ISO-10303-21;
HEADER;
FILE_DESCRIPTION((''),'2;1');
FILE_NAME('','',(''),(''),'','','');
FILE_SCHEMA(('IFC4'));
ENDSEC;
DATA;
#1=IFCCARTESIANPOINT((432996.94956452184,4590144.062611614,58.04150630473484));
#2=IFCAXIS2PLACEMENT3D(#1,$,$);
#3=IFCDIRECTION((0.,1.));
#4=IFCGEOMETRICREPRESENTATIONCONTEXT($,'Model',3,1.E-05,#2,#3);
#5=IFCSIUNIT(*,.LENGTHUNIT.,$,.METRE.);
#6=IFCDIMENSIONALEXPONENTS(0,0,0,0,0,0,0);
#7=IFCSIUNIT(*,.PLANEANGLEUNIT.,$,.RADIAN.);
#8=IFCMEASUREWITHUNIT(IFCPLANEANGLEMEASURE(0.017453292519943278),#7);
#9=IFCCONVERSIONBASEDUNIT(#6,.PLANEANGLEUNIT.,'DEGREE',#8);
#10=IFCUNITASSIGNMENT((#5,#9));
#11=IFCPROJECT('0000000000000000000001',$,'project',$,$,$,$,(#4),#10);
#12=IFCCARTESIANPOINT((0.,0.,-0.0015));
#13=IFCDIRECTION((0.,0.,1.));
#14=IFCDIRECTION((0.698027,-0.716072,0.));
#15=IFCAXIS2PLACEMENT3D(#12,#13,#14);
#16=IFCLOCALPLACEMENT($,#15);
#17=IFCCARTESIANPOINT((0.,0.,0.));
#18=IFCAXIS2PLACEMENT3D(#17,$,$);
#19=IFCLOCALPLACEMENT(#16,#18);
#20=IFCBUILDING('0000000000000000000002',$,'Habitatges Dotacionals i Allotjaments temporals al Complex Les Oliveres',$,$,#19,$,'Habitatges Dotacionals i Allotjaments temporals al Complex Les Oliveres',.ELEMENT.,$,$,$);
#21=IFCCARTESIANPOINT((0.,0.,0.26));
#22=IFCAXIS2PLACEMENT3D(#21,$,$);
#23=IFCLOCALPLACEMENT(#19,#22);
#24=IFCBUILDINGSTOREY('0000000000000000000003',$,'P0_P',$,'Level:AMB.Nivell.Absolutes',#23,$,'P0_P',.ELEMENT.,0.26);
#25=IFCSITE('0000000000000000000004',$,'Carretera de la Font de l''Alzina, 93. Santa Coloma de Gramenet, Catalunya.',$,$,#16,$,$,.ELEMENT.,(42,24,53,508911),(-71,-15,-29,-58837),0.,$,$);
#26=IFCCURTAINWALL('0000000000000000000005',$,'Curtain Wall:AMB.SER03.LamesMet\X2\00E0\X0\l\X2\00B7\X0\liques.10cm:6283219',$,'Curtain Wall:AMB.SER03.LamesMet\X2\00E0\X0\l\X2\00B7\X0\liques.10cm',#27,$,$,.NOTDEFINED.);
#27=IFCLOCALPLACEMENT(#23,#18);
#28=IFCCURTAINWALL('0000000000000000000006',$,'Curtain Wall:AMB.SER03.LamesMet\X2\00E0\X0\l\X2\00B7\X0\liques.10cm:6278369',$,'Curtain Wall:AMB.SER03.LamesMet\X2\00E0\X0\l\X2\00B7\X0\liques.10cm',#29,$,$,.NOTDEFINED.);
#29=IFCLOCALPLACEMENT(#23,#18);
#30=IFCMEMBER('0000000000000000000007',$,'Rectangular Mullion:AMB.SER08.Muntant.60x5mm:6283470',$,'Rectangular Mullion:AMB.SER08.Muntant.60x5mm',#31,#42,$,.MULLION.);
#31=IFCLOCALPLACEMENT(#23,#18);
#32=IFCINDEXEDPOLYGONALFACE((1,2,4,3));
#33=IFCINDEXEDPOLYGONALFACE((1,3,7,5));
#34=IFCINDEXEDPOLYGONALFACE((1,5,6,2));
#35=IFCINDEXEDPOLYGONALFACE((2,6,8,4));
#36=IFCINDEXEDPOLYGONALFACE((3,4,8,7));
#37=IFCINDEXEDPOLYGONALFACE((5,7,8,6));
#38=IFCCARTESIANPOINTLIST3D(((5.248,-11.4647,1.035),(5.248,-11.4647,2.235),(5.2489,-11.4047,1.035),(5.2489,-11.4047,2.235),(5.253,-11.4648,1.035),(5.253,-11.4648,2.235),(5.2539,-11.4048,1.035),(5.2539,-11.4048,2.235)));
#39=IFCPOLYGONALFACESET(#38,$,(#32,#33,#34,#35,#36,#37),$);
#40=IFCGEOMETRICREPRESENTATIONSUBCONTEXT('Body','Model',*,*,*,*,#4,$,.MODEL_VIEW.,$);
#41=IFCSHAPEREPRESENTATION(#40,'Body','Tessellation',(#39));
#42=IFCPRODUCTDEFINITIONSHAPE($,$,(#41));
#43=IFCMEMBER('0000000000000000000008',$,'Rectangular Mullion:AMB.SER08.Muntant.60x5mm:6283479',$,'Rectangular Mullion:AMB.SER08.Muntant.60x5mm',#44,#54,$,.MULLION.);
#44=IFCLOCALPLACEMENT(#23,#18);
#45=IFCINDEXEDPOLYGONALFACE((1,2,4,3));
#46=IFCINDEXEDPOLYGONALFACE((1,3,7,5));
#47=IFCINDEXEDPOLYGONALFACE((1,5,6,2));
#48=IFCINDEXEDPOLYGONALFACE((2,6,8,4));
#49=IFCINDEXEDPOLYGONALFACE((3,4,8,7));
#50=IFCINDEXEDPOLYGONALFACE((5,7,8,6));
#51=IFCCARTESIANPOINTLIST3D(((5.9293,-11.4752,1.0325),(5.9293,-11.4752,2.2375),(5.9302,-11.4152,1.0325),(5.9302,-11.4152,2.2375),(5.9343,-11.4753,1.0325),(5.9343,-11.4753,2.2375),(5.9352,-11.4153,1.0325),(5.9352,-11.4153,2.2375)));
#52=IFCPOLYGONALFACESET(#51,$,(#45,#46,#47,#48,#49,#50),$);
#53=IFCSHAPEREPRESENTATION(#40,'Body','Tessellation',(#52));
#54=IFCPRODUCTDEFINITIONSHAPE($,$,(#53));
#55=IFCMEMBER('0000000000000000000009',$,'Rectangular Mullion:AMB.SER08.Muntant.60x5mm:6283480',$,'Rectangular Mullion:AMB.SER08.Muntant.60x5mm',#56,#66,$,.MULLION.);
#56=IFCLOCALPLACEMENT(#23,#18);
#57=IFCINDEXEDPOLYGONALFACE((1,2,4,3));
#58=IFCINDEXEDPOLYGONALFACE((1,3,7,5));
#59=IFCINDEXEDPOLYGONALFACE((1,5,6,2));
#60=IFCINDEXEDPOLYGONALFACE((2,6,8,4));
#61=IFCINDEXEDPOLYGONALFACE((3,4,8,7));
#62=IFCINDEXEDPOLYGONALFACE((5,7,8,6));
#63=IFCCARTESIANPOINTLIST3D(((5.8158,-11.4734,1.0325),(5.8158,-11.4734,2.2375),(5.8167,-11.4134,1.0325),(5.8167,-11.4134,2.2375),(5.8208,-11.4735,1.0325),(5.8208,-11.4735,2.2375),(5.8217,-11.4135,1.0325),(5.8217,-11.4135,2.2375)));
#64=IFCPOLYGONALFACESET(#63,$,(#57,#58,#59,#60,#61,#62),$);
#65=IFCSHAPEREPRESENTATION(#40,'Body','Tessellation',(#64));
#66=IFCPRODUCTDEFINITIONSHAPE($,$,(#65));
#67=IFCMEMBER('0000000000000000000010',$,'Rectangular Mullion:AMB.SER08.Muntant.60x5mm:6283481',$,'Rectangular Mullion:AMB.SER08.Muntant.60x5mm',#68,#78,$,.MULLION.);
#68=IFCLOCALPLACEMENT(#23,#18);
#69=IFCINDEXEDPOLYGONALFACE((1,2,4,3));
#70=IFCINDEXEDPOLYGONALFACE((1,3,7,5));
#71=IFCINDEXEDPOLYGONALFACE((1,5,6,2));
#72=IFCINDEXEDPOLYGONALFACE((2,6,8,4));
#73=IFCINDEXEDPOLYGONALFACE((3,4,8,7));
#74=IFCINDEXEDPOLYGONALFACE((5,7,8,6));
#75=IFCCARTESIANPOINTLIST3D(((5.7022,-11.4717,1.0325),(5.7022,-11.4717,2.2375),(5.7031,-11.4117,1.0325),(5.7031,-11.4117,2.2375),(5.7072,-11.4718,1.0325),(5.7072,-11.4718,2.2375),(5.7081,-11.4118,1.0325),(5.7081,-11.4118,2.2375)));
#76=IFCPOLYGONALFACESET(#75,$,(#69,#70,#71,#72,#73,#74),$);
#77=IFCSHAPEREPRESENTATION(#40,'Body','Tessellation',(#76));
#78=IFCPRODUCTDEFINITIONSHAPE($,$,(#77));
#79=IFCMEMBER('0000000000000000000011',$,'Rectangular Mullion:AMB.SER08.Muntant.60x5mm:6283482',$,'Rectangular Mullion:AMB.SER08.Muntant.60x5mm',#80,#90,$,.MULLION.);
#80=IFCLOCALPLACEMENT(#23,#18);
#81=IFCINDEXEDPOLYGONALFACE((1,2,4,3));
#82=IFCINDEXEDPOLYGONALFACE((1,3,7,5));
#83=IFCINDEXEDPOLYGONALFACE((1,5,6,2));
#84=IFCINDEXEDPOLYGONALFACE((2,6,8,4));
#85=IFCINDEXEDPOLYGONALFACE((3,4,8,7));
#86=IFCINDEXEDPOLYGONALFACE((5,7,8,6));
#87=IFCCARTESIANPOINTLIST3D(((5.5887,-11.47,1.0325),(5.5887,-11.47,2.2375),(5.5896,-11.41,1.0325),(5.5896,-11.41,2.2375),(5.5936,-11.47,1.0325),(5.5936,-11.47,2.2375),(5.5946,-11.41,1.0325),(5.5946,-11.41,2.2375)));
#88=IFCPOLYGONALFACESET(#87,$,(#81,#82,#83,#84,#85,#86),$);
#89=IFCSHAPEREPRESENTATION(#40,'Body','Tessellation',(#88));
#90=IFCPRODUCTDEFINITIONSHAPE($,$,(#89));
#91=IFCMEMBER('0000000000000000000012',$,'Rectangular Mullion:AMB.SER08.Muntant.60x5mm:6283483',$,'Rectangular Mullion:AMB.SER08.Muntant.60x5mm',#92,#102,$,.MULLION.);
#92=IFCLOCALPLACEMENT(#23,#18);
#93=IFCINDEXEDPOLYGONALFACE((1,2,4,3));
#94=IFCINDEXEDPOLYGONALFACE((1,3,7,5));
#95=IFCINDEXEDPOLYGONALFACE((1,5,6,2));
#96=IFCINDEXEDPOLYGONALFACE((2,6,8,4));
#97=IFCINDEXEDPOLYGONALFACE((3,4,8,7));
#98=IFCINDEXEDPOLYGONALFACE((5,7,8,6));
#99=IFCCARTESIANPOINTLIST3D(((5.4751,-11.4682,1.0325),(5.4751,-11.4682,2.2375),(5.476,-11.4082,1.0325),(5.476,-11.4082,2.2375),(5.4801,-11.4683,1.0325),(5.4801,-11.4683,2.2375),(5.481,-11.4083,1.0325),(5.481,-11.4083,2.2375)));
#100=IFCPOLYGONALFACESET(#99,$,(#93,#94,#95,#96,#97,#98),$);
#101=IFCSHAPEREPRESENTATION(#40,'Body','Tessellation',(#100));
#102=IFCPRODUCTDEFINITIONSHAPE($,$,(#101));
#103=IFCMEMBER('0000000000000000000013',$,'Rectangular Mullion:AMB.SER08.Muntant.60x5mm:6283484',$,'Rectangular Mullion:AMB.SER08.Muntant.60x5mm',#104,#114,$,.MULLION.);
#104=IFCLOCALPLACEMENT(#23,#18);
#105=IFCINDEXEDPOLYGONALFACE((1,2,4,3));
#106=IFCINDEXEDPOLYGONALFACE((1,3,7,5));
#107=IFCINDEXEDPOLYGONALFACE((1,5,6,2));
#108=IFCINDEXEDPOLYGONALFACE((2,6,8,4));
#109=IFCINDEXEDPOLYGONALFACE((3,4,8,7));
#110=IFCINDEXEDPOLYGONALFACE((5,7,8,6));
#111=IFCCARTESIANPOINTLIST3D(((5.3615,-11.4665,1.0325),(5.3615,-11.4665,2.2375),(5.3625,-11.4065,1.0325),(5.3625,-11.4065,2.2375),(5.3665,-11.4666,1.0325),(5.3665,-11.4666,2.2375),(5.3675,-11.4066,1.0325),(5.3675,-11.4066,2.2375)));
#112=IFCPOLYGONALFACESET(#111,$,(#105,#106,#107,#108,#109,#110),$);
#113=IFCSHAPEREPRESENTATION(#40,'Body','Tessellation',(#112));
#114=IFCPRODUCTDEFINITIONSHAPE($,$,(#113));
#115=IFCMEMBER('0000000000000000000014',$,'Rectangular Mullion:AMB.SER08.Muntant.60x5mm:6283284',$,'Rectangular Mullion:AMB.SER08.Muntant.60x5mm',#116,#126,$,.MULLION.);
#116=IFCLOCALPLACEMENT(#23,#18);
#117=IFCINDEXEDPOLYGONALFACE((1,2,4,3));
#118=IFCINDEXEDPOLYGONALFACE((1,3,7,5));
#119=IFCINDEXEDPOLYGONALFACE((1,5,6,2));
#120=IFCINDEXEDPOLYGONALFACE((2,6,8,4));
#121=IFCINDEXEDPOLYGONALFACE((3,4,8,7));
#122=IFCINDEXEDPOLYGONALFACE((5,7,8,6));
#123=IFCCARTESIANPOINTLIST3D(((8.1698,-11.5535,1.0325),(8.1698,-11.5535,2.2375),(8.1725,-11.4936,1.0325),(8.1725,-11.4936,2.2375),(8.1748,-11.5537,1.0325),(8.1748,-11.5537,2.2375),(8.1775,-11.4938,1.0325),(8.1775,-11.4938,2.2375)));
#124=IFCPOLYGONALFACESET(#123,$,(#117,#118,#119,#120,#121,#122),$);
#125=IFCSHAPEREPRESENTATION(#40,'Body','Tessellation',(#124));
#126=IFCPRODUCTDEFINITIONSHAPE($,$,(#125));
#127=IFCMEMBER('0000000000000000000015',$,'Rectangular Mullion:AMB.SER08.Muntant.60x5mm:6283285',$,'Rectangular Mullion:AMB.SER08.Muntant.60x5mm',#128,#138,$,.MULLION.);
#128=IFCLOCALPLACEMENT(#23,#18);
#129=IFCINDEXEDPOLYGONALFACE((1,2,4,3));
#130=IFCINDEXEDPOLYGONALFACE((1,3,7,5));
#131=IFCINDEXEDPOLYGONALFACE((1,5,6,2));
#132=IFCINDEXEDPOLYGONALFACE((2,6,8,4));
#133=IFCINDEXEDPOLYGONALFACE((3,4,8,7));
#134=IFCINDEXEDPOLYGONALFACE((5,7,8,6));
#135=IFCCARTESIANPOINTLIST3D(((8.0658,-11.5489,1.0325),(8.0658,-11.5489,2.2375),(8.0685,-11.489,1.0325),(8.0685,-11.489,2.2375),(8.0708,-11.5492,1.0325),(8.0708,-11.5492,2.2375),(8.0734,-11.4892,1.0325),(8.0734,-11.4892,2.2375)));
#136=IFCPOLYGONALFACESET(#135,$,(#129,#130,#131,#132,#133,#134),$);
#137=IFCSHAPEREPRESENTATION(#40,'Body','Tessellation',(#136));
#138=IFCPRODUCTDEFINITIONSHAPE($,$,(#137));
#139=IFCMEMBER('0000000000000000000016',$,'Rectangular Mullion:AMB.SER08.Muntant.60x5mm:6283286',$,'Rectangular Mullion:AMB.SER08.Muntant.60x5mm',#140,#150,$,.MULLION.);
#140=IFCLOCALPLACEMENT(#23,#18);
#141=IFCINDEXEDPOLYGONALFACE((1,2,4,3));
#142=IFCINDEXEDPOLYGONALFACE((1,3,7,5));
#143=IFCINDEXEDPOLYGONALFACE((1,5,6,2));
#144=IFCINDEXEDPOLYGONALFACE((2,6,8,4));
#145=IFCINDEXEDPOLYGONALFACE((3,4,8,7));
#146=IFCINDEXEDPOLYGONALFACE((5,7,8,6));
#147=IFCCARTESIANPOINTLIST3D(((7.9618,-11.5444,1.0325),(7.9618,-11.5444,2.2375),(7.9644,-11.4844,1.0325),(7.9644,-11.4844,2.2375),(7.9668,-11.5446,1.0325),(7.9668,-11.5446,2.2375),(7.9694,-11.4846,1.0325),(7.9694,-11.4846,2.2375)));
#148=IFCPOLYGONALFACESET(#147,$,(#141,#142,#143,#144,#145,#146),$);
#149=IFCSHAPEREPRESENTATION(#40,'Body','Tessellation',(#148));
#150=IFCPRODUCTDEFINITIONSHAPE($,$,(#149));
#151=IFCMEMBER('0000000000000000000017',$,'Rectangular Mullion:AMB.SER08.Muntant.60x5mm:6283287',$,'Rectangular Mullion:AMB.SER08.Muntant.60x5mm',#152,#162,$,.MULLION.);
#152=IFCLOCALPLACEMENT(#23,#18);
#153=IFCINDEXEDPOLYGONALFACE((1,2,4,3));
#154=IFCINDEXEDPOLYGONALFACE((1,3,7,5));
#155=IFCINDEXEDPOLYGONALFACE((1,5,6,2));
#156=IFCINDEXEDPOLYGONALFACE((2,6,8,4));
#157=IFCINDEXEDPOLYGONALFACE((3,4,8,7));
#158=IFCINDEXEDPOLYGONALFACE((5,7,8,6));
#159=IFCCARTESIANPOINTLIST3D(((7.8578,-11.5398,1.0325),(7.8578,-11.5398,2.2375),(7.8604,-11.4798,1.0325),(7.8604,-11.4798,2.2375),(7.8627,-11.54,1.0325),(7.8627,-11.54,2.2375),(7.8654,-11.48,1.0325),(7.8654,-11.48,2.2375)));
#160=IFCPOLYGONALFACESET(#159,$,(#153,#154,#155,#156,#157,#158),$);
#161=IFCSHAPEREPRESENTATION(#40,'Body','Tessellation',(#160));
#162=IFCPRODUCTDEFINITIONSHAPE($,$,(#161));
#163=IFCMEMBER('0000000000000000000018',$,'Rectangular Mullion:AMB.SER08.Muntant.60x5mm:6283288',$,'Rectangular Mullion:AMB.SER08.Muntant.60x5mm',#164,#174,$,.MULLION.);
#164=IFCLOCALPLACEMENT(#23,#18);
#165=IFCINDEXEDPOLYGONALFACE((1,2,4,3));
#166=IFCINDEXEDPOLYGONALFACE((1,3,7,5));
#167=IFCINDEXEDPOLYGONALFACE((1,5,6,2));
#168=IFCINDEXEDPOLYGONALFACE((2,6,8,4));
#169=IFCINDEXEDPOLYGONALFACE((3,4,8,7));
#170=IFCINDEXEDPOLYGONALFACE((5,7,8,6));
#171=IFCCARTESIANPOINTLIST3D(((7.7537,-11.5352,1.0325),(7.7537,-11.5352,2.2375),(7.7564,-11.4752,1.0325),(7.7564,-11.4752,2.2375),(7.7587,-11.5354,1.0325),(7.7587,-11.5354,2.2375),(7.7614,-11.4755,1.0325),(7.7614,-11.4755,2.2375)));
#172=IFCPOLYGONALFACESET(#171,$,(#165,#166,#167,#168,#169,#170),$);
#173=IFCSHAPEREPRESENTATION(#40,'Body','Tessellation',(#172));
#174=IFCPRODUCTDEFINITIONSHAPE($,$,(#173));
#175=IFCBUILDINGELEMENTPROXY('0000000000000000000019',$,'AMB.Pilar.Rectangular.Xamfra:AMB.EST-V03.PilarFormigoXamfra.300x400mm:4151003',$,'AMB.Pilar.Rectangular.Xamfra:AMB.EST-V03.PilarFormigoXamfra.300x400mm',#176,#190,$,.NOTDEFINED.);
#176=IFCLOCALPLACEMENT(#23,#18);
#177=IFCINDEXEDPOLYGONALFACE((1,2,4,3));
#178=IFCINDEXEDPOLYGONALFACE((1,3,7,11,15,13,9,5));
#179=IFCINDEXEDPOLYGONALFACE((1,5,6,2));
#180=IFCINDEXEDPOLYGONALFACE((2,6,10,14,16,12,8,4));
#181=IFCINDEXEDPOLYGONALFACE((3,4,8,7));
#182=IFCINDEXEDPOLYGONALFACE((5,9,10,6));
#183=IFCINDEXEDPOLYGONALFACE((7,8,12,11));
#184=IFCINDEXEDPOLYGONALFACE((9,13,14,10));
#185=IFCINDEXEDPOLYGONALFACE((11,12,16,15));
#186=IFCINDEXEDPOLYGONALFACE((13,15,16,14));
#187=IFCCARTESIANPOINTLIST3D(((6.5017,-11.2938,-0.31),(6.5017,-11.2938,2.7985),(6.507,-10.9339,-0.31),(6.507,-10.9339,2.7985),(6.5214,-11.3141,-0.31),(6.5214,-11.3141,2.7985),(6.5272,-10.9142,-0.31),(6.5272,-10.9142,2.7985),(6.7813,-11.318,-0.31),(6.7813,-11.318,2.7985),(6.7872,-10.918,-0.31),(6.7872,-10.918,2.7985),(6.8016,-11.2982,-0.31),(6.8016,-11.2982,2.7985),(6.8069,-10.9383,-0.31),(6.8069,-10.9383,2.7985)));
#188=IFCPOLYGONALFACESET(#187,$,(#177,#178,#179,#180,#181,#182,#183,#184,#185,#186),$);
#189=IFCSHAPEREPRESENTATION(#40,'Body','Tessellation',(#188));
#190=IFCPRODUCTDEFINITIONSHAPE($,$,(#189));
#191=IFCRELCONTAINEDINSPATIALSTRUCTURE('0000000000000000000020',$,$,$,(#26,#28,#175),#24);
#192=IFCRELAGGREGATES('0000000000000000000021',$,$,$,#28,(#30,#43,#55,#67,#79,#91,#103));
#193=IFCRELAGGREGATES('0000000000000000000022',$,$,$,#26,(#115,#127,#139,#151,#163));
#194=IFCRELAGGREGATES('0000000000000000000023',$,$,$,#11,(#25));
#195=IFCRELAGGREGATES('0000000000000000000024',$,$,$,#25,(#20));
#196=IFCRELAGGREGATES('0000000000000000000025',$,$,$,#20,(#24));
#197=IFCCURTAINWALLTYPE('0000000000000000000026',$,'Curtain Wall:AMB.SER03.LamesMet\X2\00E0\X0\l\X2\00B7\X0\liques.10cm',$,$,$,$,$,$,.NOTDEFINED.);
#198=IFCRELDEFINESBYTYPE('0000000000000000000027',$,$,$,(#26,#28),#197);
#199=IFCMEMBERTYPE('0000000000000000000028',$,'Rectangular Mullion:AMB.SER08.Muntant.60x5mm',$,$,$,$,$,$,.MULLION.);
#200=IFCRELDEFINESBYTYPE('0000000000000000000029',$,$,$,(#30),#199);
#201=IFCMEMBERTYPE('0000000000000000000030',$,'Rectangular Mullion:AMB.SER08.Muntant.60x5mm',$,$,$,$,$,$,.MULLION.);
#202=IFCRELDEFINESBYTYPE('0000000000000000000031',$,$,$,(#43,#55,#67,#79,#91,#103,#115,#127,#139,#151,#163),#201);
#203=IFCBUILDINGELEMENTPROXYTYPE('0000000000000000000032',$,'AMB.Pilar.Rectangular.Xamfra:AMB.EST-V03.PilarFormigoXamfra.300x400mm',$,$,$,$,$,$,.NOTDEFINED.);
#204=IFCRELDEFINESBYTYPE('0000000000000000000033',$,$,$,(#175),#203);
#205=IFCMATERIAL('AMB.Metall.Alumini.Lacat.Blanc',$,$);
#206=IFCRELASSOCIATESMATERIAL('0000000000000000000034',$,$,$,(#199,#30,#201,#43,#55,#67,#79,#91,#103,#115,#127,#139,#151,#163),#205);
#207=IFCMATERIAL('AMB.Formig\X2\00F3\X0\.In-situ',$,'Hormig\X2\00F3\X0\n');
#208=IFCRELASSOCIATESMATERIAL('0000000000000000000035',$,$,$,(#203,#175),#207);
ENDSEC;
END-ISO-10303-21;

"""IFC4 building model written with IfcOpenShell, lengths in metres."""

from ifc_helpers import new_model, entity, si_unit, converted_unit, direction, frame, origin, place, context, subcontext, project, spatial, indexed_curve, outline, extrude, source, transform, mapped, material, type_object, type_shapes, element, aggregate, save


model = new_model("IFC4")

# Units and contexts
model_context = context("Model", 3, precision=1e-05, world=frame((432996.94956452184, 4590144.062611614, 58.04150630473484)), true_north=direction((0.0, 1.0)))
body_context = subcontext(model_context, "Body", "Model", "MODEL_VIEW")
ifc_project = project(units=[si_unit("LENGTHUNIT", "METRE"), converted_unit("PLANEANGLEUNIT", "DEGREE", entity("IfcPlaneAngleMeasure", 0.017453292519943278), si_unit("PLANEANGLEUNIT", "RADIAN"), dimensions=[0, 0, 0, 0, 0, 0, 0])], contexts=[model_context])

# Site, building, storey
site_placement = place(None, frame((0.0, 0.0, -0.0015), z_axis=(0.0, 0.0, 1.0), x_axis=(0.698027, -0.716072, 0.0)))
site = spatial("IfcSite", under=ifc_project, at=site_placement, Name="Carretera de la Font de l'Alzina, 93. Santa Coloma de Gramenet, Catalunya.", CompositionType="ELEMENT", RefLatitude=(42, 24, 53, 508911), RefLongitude=(-71, -15, -29, -58837), RefElevation=0.0)
building_placement = place(site_placement, origin())
building = spatial("IfcBuilding", under=site, at=building_placement, Name="Habitatges Dotacionals i Allotjaments temporals al Complex Les Oliveres", LongName="Habitatges Dotacionals i Allotjaments temporals al Complex Les Oliveres", CompositionType="ELEMENT")
storey_placement = place(building_placement, frame((0.0, 0.0, 0.26)))
storey = spatial("IfcBuildingStorey", under=building, at=storey_placement, Name="P0_P", ObjectType="Level:AMB.Nivell.Absolutes", LongName="P0_P", CompositionType="ELEMENT", Elevation=0.26)

# Shared definitions
ifc_material_1 = material(Name="AMB.Formigó.In-situ", Category="Hormigón")

# Curtain wall
curtain_wall_type = type_object("IfcCurtainWallType", Name="Curtain Wall:AMB.SER03.LamesMetàl·liques.10cm", PredefinedType="NOTDEFINED")
curtain_wall_1_placement = place(storey_placement, frame((0.0, 0.0, -0.26)))
curtain_wall_1 = element("IfcCurtainWall", 1, at=curtain_wall_1_placement, inside=storey, type_object=curtain_wall_type, Name="Curtain Wall:AMB.SER03.LamesMetàl·liques.10cm:6283219", ObjectType="Curtain Wall:AMB.SER03.LamesMetàl·liques.10cm", PredefinedType="NOTDEFINED")
ifc_material_2 = material(Name="AMB.Metall.Alumini.Lacat.Blanc")

# Curtain wall
curtain_wall_2_placement = place(storey_placement, frame((0.0, 0.0, -0.26)))
curtain_wall_2 = element("IfcCurtainWall", 2, at=curtain_wall_2_placement, inside=storey, type_object=curtain_wall_type, Name="Curtain Wall:AMB.SER03.LamesMetàl·liques.10cm:6278369", ObjectType="Curtain Wall:AMB.SER03.LamesMetàl·liques.10cm", PredefinedType="NOTDEFINED")

# Members
member_type_1 = type_object("IfcMemberType", Name="Rectangular Mullion:AMB.SER08.Muntant.60x5mm", PredefinedType="MULLION", material=ifc_material_2)
shared_shape_1 = source(origin(), body_context, "Body", "SweptSolid", [
    extrude(outline(indexed_curve([(-0.0025, -0.03), (0.0025, -0.03), (0.0025, 0.03), (-0.0025, 0.03), (-0.0025, -0.03)], self_intersect=False)), frame((-0.0025, 0.03, -1.2), z_axis=(0.0, 0.0, 1.0), x_axis=(-1.0, 0.0, 0.0)), (0.0, 0.0, 1.0), 1.2),
])
type_shapes(member_type_1, [shared_shape_1])
member_1_placement = place(curtain_wall_2_placement, frame((5.248, -11.4647, 1.295), z_axis=(0.0, 0.0, -1.0), x_axis=(-0.999883, 0.015319, 0.0)))
member_1 = element("IfcMember", 3, at=member_1_placement, type_object=member_type_1, material=ifc_material_2, Name="Rectangular Mullion:AMB.SER08.Muntant.60x5mm:6283470", ObjectType="Rectangular Mullion:AMB.SER08.Muntant.60x5mm", PredefinedType="MULLION", context=body_context, shape_type="MappedRepresentation", body=[
    mapped(shared_shape_1, transform((0.0, 0.0, 0.0), scale=1.0)),
])
member_type_2 = type_object("IfcMemberType", Name="Rectangular Mullion:AMB.SER08.Muntant.60x5mm", PredefinedType="MULLION", material=ifc_material_2)
shared_shape_2 = source(origin(), body_context, "Body", "SweptSolid", [
    extrude(outline(indexed_curve([(-0.0025, -0.03), (0.0025, -0.03), (0.0025, 0.03), (-0.0025, 0.03), (-0.0025, -0.03)], self_intersect=False)), frame((0.0, 0.03, -1.205), z_axis=(0.0, 0.0, 1.0), x_axis=(-1.0, 0.0, 0.0)), (0.0, 0.0, 1.0), 1.205),
])
type_shapes(member_type_2, [shared_shape_2])
member_2_placement = place(curtain_wall_2_placement, frame((5.9318, -11.4752, 1.2925), z_axis=(0.0, 0.0, -1.0), x_axis=(-0.999883, 0.015319, 0.0)))
member_2 = element("IfcMember", 4, at=member_2_placement, type_object=member_type_2, material=ifc_material_2, Name="Rectangular Mullion:AMB.SER08.Muntant.60x5mm:6283479", ObjectType="Rectangular Mullion:AMB.SER08.Muntant.60x5mm", PredefinedType="MULLION", context=body_context, shape_type="MappedRepresentation", body=[
    mapped(shared_shape_2, transform((0.0, 0.0, 0.0), scale=1.0)),
])
member_3_placement = place(curtain_wall_2_placement, frame((5.8183, -11.4735, 1.2925), z_axis=(0.0, 0.0, -1.0), x_axis=(-0.999883, 0.015319, 0.0)))
member_3 = element("IfcMember", 5, at=member_3_placement, type_object=member_type_2, material=ifc_material_2, Name="Rectangular Mullion:AMB.SER08.Muntant.60x5mm:6283480", ObjectType="Rectangular Mullion:AMB.SER08.Muntant.60x5mm", PredefinedType="MULLION", context=body_context, shape_type="MappedRepresentation", body=[
    mapped(shared_shape_2, transform((0.0, 0.0, 0.0), scale=1.0)),
])
member_4_placement = place(curtain_wall_2_placement, frame((5.7047, -11.4717, 1.2925), z_axis=(0.0, 0.0, -1.0), x_axis=(-0.999883, 0.015319, 0.0)))
member_4 = element("IfcMember", 6, at=member_4_placement, type_object=member_type_2, material=ifc_material_2, Name="Rectangular Mullion:AMB.SER08.Muntant.60x5mm:6283481", ObjectType="Rectangular Mullion:AMB.SER08.Muntant.60x5mm", PredefinedType="MULLION", context=body_context, shape_type="MappedRepresentation", body=[
    mapped(shared_shape_2, transform((0.0, 0.0, 0.0), scale=1.0)),
])
member_5_placement = place(curtain_wall_2_placement, frame((5.5912, -11.47, 1.2925), z_axis=(0.0, 0.0, -1.0), x_axis=(-0.999883, 0.015319, 0.0)))
member_5 = element("IfcMember", 7, at=member_5_placement, type_object=member_type_2, material=ifc_material_2, Name="Rectangular Mullion:AMB.SER08.Muntant.60x5mm:6283482", ObjectType="Rectangular Mullion:AMB.SER08.Muntant.60x5mm", PredefinedType="MULLION", context=body_context, shape_type="MappedRepresentation", body=[
    mapped(shared_shape_2, transform((0.0, 0.0, 0.0), scale=1.0)),
])
member_6_placement = place(curtain_wall_2_placement, frame((5.4776, -11.4683, 1.2925), z_axis=(0.0, 0.0, -1.0), x_axis=(-0.999883, 0.015319, 0.0)))
member_6 = element("IfcMember", 8, at=member_6_placement, type_object=member_type_2, material=ifc_material_2, Name="Rectangular Mullion:AMB.SER08.Muntant.60x5mm:6283483", ObjectType="Rectangular Mullion:AMB.SER08.Muntant.60x5mm", PredefinedType="MULLION", context=body_context, shape_type="MappedRepresentation", body=[
    mapped(shared_shape_2, transform((0.0, 0.0, 0.0), scale=1.0)),
])
member_7_placement = place(curtain_wall_2_placement, frame((5.364, -11.4665, 1.2925), z_axis=(0.0, 0.0, -1.0), x_axis=(-0.999883, 0.015319, 0.0)))
member_7 = element("IfcMember", 9, at=member_7_placement, type_object=member_type_2, material=ifc_material_2, Name="Rectangular Mullion:AMB.SER08.Muntant.60x5mm:6283484", ObjectType="Rectangular Mullion:AMB.SER08.Muntant.60x5mm", PredefinedType="MULLION", context=body_context, shape_type="MappedRepresentation", body=[
    mapped(shared_shape_2, transform((0.0, 0.0, 0.0), scale=1.0)),
])
aggregate(curtain_wall_2, [member_1, member_2, member_3, member_4, member_5, member_6, member_7])
member_8_placement = place(curtain_wall_1_placement, frame((8.1723, -11.5536, 1.2925), z_axis=(0.0, 0.0, -1.0), x_axis=(-0.99903, 0.044031, 0.0)))
member_8 = element("IfcMember", 10, at=member_8_placement, type_object=member_type_2, material=ifc_material_2, Name="Rectangular Mullion:AMB.SER08.Muntant.60x5mm:6283284", ObjectType="Rectangular Mullion:AMB.SER08.Muntant.60x5mm", PredefinedType="MULLION", context=body_context, shape_type="MappedRepresentation", body=[
    mapped(shared_shape_2, transform((0.0, 0.0, 0.0), scale=1.0)),
])
member_9_placement = place(curtain_wall_1_placement, frame((8.0683, -11.5491, 1.2925), z_axis=(0.0, 0.0, -1.0), x_axis=(-0.99903, 0.044031, 0.0)))
member_9 = element("IfcMember", 11, at=member_9_placement, type_object=member_type_2, material=ifc_material_2, Name="Rectangular Mullion:AMB.SER08.Muntant.60x5mm:6283285", ObjectType="Rectangular Mullion:AMB.SER08.Muntant.60x5mm", PredefinedType="MULLION", context=body_context, shape_type="MappedRepresentation", body=[
    mapped(shared_shape_2, transform((0.0, 0.0, 0.0), scale=1.0)),
])
member_10_placement = place(curtain_wall_1_placement, frame((7.9643, -11.5445, 1.2925), z_axis=(0.0, 0.0, -1.0), x_axis=(-0.99903, 0.044031, 0.0)))
member_10 = element("IfcMember", 12, at=member_10_placement, type_object=member_type_2, material=ifc_material_2, Name="Rectangular Mullion:AMB.SER08.Muntant.60x5mm:6283286", ObjectType="Rectangular Mullion:AMB.SER08.Muntant.60x5mm", PredefinedType="MULLION", context=body_context, shape_type="MappedRepresentation", body=[
    mapped(shared_shape_2, transform((0.0, 0.0, 0.0), scale=1.0)),
])
member_11_placement = place(curtain_wall_1_placement, frame((7.8602, -11.5399, 1.2925), z_axis=(0.0, 0.0, -1.0), x_axis=(-0.99903, 0.044031, 0.0)))
member_11 = element("IfcMember", 13, at=member_11_placement, type_object=member_type_2, material=ifc_material_2, Name="Rectangular Mullion:AMB.SER08.Muntant.60x5mm:6283287", ObjectType="Rectangular Mullion:AMB.SER08.Muntant.60x5mm", PredefinedType="MULLION", context=body_context, shape_type="MappedRepresentation", body=[
    mapped(shared_shape_2, transform((0.0, 0.0, 0.0), scale=1.0)),
])
member_12_placement = place(curtain_wall_1_placement, frame((7.7562, -11.5353, 1.2925), z_axis=(0.0, 0.0, -1.0), x_axis=(-0.99903, 0.044031, 0.0)))
member_12 = element("IfcMember", 14, at=member_12_placement, type_object=member_type_2, material=ifc_material_2, Name="Rectangular Mullion:AMB.SER08.Muntant.60x5mm:6283288", ObjectType="Rectangular Mullion:AMB.SER08.Muntant.60x5mm", PredefinedType="MULLION", context=body_context, shape_type="MappedRepresentation", body=[
    mapped(shared_shape_2, transform((0.0, 0.0, 0.0), scale=1.0)),
])
aggregate(curtain_wall_1, [member_8, member_9, member_10, member_11, member_12])

# Building element proxy
building_element_proxy_type = type_object("IfcBuildingElementProxyType", Name="AMB.Pilar.Rectangular.Xamfra:AMB.EST-V03.PilarFormigoXamfra.300x400mm", PredefinedType="NOTDEFINED", material=ifc_material_1)
shared_shape_3 = source(origin(), body_context, "Body", "SweptSolid", [
    extrude(outline(indexed_curve([(-0.13, -0.2), (0.13, -0.2), (0.15, -0.18), (0.15, 0.18), (0.13, 0.2), (-0.13, 0.2), (-0.15, 0.18), (-0.15, -0.18), (-0.13, -0.2)], self_intersect=False)), frame((0.0, 0.0, -0.05), z_axis=(0.0, 0.0, 1.0), x_axis=(-1.0, 0.0, 0.0)), (0.0, 0.0, 1.0), 3.1085),
])
type_shapes(building_element_proxy_type, [shared_shape_3])
proxy_placement = place(storey_placement, frame((6.6543, -11.1161, -0.26), z_axis=(0.0, 0.0, 1.0), x_axis=(0.999892, -0.014677, 0.0)))
element("IfcBuildingElementProxy", 15, at=proxy_placement, inside=storey, type_object=building_element_proxy_type, material=ifc_material_1, Name="AMB.Pilar.Rectangular.Xamfra:AMB.EST-V03.PilarFormigoXamfra.300x400mm:4151003", ObjectType="AMB.Pilar.Rectangular.Xamfra:AMB.EST-V03.PilarFormigoXamfra.300x400mm", PredefinedType="NOTDEFINED", context=body_context, shape_type="MappedRepresentation", body=[
    mapped(shared_shape_3, transform((0.0, 0.0, 0.0), scale=1.0)),
])

save(model, "model.ifc")
